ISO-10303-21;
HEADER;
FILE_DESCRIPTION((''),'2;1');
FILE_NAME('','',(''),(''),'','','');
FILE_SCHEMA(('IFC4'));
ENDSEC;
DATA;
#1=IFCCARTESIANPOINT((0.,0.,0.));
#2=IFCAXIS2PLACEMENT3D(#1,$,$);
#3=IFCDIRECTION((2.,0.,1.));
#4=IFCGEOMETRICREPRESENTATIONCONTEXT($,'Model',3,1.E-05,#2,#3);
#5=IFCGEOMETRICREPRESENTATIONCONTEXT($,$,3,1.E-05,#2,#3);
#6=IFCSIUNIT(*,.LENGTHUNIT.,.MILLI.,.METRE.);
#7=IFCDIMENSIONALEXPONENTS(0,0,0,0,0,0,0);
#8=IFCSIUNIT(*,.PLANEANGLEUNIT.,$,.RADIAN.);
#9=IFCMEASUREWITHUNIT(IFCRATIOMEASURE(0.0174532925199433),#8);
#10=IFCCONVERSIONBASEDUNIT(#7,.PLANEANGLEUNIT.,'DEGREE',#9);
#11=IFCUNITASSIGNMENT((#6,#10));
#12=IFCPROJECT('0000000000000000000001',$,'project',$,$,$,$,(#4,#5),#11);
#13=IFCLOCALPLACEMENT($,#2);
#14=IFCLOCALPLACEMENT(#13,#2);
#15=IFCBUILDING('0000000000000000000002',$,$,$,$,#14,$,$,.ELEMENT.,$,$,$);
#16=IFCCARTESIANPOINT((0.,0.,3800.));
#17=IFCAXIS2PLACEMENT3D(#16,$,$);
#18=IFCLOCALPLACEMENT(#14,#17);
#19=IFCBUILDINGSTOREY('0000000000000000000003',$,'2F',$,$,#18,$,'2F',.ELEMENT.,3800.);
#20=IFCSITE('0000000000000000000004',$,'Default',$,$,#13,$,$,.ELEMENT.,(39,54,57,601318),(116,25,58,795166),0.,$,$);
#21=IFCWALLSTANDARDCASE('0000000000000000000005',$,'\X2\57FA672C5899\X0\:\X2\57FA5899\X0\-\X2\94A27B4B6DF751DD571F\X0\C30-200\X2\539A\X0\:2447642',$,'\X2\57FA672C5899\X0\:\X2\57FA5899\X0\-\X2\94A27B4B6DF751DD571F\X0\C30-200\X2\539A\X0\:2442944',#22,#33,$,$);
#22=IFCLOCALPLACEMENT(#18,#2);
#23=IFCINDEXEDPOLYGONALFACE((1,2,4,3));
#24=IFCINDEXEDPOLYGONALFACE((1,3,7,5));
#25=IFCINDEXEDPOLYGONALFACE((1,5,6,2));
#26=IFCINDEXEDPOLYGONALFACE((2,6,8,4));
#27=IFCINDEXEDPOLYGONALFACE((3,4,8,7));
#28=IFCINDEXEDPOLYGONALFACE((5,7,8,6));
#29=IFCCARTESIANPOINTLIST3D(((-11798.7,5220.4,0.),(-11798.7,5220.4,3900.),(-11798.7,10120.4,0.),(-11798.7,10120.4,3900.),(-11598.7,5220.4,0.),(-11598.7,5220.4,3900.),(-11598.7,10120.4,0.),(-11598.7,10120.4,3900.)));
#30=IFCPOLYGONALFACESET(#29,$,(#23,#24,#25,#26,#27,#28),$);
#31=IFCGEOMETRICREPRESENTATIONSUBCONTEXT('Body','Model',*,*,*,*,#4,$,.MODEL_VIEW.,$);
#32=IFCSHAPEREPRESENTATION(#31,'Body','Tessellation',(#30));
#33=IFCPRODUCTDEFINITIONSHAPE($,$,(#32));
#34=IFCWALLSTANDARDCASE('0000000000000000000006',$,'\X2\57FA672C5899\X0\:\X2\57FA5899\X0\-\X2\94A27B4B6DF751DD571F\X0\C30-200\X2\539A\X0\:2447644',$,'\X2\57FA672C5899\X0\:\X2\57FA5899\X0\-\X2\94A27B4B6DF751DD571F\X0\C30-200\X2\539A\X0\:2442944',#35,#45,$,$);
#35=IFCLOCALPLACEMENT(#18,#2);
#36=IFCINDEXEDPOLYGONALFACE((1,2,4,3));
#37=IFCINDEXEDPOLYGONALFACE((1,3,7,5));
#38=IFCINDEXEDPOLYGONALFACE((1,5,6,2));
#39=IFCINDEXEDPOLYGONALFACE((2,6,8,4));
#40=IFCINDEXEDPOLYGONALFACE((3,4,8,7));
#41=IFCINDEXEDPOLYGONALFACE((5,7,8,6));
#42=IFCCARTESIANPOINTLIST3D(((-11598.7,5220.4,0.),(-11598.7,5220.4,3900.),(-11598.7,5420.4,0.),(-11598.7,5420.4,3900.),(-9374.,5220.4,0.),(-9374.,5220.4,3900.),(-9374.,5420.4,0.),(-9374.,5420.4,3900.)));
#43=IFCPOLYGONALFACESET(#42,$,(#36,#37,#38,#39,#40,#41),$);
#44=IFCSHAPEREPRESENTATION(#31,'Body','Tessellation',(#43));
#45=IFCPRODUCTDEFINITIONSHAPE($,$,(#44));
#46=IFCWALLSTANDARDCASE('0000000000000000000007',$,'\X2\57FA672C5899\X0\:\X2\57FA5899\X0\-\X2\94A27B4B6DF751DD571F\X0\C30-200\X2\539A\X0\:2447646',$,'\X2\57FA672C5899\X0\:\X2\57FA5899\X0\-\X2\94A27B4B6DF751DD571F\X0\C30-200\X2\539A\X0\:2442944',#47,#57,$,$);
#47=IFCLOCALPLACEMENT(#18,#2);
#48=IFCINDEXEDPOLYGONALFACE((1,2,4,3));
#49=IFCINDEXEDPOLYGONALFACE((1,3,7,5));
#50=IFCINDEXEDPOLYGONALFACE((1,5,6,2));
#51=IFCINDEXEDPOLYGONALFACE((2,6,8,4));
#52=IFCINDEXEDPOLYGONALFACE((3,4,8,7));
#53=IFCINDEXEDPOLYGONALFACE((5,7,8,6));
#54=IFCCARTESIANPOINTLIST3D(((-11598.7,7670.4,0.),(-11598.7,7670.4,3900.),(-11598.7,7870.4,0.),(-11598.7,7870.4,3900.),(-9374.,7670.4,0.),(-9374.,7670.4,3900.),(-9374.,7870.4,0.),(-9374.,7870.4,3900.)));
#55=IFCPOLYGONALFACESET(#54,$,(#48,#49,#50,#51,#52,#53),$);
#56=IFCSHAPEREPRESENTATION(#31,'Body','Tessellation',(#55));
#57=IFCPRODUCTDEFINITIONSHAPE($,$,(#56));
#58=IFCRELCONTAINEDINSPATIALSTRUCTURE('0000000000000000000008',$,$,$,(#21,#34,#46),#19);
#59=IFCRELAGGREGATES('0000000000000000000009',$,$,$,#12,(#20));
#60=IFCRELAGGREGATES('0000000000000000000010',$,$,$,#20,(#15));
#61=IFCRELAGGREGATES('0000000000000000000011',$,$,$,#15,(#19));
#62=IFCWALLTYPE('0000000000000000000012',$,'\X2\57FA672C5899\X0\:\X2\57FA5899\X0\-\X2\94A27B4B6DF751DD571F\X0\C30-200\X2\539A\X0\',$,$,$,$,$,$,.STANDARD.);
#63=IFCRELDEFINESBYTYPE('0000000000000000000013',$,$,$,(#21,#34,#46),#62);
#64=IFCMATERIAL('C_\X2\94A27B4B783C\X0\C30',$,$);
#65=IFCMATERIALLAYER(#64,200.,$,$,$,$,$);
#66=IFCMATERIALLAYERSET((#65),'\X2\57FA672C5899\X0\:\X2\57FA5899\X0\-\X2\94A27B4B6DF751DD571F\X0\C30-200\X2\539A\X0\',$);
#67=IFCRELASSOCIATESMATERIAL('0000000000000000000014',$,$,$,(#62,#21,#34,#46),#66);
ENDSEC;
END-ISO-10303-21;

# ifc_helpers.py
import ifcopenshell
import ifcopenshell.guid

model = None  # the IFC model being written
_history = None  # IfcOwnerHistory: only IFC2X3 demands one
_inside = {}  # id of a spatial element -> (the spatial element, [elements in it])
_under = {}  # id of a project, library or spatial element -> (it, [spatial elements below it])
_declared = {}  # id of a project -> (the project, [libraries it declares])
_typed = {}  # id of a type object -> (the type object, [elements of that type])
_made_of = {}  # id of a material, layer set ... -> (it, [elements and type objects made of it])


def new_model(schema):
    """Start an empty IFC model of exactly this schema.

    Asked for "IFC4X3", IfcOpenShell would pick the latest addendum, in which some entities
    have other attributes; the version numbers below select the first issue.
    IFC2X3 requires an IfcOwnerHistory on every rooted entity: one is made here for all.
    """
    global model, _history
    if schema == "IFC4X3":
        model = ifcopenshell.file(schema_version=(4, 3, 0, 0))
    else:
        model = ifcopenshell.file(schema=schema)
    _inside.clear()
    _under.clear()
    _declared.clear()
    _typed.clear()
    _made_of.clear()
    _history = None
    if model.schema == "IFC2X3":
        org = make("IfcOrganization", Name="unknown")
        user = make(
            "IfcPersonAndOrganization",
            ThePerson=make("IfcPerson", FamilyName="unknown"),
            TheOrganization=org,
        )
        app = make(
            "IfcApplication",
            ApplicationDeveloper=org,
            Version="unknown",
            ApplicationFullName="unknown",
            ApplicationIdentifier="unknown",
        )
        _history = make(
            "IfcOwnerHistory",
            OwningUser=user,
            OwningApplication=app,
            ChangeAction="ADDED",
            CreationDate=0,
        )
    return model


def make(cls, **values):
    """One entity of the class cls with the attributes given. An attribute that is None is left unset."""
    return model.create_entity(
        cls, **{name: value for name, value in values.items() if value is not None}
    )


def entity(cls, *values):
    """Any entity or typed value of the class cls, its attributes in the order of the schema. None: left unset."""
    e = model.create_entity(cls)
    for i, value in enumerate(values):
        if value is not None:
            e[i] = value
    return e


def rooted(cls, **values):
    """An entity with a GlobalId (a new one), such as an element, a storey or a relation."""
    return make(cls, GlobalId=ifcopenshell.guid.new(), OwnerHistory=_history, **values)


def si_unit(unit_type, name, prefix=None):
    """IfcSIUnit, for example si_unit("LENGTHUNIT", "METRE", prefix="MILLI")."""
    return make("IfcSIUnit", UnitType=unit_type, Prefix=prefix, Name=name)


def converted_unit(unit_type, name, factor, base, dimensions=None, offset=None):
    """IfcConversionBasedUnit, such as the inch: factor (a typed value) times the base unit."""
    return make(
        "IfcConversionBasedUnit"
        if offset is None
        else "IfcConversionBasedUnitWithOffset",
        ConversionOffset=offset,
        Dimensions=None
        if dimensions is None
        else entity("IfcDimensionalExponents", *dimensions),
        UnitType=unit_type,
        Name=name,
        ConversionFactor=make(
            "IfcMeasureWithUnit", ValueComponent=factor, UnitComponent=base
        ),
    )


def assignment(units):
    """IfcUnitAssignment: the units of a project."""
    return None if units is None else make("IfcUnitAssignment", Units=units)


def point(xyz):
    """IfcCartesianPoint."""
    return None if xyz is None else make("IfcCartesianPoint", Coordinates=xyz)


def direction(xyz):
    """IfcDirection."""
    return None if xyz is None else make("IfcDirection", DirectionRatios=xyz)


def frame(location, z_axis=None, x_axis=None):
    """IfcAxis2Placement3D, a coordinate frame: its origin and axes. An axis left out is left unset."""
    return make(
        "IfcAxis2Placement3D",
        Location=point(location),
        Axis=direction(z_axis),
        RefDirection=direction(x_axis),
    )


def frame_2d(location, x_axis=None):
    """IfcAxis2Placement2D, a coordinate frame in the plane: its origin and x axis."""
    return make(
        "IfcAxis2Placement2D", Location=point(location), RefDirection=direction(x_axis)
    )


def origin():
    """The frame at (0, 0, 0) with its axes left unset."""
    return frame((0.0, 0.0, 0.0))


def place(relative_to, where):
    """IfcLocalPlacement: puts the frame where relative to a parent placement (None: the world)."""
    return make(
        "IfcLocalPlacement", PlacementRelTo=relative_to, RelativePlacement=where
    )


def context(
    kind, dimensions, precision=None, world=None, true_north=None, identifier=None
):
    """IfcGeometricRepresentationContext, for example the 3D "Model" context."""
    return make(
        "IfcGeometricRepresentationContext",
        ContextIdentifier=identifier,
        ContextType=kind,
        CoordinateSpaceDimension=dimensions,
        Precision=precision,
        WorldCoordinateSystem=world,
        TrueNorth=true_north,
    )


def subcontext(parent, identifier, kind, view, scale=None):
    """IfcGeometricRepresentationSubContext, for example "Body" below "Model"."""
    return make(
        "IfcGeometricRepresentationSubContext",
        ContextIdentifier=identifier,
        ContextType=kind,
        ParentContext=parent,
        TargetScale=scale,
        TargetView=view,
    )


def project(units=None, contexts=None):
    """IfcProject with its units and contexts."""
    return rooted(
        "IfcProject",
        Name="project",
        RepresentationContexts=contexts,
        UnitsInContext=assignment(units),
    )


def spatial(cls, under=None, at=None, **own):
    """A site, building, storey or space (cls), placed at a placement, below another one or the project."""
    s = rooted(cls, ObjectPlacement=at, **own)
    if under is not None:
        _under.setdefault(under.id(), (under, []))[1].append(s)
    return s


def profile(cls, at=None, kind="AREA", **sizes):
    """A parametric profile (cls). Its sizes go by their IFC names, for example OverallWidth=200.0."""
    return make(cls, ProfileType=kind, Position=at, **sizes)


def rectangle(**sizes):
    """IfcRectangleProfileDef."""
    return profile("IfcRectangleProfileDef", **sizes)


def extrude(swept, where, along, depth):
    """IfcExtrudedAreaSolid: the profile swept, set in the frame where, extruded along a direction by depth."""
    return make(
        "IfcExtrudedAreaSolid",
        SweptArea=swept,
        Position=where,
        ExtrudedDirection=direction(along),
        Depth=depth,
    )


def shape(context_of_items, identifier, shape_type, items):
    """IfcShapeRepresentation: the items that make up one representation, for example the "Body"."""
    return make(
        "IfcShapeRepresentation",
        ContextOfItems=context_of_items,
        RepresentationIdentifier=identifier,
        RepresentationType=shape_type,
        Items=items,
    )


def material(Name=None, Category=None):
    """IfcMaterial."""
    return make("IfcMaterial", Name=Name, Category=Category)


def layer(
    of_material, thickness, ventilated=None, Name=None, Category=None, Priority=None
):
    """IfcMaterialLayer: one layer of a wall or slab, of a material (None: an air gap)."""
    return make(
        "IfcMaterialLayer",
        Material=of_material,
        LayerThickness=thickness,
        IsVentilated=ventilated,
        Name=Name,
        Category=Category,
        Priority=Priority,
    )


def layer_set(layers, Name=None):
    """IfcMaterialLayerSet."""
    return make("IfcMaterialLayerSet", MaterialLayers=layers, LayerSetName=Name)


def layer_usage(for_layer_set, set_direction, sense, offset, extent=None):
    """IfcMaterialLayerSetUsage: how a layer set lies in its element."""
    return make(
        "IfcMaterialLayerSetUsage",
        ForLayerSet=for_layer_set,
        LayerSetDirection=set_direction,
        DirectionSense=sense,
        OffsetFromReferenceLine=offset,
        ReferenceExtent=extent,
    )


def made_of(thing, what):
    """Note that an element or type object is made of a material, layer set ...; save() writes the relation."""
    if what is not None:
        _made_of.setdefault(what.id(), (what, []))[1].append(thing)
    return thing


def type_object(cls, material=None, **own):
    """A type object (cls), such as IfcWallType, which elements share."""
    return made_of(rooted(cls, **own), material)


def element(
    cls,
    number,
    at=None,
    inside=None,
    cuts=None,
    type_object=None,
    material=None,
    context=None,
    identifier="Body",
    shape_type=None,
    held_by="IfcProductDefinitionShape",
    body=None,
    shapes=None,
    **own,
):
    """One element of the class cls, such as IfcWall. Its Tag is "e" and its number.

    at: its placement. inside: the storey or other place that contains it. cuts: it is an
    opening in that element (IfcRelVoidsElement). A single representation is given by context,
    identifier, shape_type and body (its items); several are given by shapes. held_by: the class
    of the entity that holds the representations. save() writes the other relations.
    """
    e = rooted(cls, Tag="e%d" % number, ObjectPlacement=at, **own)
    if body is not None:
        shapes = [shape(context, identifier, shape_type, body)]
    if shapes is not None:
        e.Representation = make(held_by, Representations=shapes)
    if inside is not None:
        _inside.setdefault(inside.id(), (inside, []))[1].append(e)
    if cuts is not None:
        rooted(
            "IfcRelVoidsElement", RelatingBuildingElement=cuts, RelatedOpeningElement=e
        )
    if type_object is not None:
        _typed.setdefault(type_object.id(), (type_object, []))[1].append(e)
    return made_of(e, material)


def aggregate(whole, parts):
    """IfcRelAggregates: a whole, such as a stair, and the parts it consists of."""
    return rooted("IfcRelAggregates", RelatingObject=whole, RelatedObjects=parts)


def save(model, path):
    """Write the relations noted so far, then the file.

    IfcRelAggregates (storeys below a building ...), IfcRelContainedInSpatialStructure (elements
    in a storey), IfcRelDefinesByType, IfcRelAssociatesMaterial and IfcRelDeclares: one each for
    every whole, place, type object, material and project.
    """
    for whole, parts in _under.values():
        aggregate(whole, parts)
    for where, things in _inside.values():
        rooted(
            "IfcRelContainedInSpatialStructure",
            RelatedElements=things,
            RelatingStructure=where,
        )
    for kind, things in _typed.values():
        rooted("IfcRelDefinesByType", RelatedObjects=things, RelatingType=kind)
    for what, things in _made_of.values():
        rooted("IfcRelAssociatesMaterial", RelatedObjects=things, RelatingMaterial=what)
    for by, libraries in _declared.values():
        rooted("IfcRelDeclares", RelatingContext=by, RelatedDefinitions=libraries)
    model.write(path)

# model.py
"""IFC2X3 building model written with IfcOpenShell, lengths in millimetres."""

from ifc_helpers import new_model, entity, si_unit, converted_unit, direction, frame, frame_2d, origin, place, context, subcontext, project, spatial, rectangle, extrude, material, layer, layer_set, layer_usage, type_object, element, save


model = new_model("IFC2X3")

# Units and contexts
model_context = context("Model", 3, precision=1e-05, world=origin(), true_north=direction((2.0, 0.0, 1.0)))
context_of_model = context(None, 3, precision=1e-05, world=origin(), true_north=direction((2.0, 0.0, 1.0)))
body_context = subcontext(model_context, "Body", "Model", "MODEL_VIEW")
ifc_project = project(units=[si_unit("LENGTHUNIT", "METRE", prefix="MILLI"), converted_unit("PLANEANGLEUNIT", "DEGREE", entity("IfcRatioMeasure", 0.0174532925199433), si_unit("PLANEANGLEUNIT", "RADIAN"), dimensions=[0, 0, 0, 0, 0, 0, 0])], contexts=[model_context, context_of_model])

# Site, building, storey
site_placement = place(None, origin())
site = spatial("IfcSite", under=ifc_project, at=site_placement, Name="Default", CompositionType="ELEMENT", RefLatitude=(39, 54, 57, 601318), RefLongitude=(116, 25, 58, 795166), RefElevation=0.0)
building_placement = place(site_placement, origin())
building = spatial("IfcBuilding", under=site, at=building_placement, CompositionType="ELEMENT")
storey_placement = place(building_placement, frame((0.0, 0.0, 3800.0)))
storey = spatial("IfcBuildingStorey", under=building, at=storey_placement, Name="2F", LongName="2F", CompositionType="ELEMENT", Elevation=3800.0)

# Shared definitions
ifc_material_1 = material(Name="C_钢筋砼C30")

# Walls
ifc_layer_1 = layer(ifc_material_1, 200.0)
ifc_layer_set_1 = layer_set([ifc_layer_1], Name="基本墙:基墙-钢筋混凝土C30-200厚")
ifc_layer_usage_1 = layer_usage(ifc_layer_set_1, "AXIS2", "POSITIVE", -100.0)
wall_type_1 = type_object("IfcWallType", Name="基本墙:基墙-钢筋混凝土C30-200厚", PredefinedType="STANDARD", material=ifc_layer_set_1)
wall_1_placement = place(storey_placement, frame((-11698.7, 10120.4, 0.0), z_axis=(0.0, 0.0, 1.0), x_axis=(0.0, -1.0, 0.0)))
element("IfcWallStandardCase", 1, at=wall_1_placement, inside=storey, type_object=wall_type_1, material=ifc_layer_usage_1, Name="基本墙:基墙-钢筋混凝土C30-200厚:2447642", ObjectType="基本墙:基墙-钢筋混凝土C30-200厚:2442944", context=body_context, shape_type="SweptSolid", body=[
    extrude(rectangle(XDim=4900.0, YDim=200.0, at=frame_2d((2450.0, 0.0), x_axis=(-1.0, 0.0))), origin(), (0.0, 0.0, 1.0), 3900.0),
])
ifc_layer_usage_2 = layer_usage(ifc_layer_set_1, "AXIS2", "POSITIVE", -100.0)
wall_2_placement = place(storey_placement, frame((-11598.7, 5320.4, 0.0)))
element("IfcWallStandardCase", 2, at=wall_2_placement, inside=storey, type_object=wall_type_1, material=ifc_layer_usage_2, Name="基本墙:基墙-钢筋混凝土C30-200厚:2447644", ObjectType="基本墙:基墙-钢筋混凝土C30-200厚:2442944", context=body_context, shape_type="SweptSolid", body=[
    extrude(rectangle(XDim=2224.6, YDim=200.0, at=frame_2d((1112.3, 0.0), x_axis=(-1.0, 0.0))), origin(), (0.0, 0.0, 1.0), 3900.0),
])
ifc_layer_usage_3 = layer_usage(ifc_layer_set_1, "AXIS2", "POSITIVE", -100.0)
wall_3_placement = place(storey_placement, frame((-11598.7, 7770.4, 0.0)))
element("IfcWallStandardCase", 3, at=wall_3_placement, inside=storey, type_object=wall_type_1, material=ifc_layer_usage_3, Name="基本墙:基墙-钢筋混凝土C30-200厚:2447646", ObjectType="基本墙:基墙-钢筋混凝土C30-200厚:2442944", context=body_context, shape_type="SweptSolid", body=[
    extrude(rectangle(XDim=2224.6, YDim=200.0, at=frame_2d((1112.3, 0.0), x_axis=(-1.0, 0.0))), origin(), (0.0, 0.0, 1.0), 3900.0),
])

save(model, "model.ifc")
